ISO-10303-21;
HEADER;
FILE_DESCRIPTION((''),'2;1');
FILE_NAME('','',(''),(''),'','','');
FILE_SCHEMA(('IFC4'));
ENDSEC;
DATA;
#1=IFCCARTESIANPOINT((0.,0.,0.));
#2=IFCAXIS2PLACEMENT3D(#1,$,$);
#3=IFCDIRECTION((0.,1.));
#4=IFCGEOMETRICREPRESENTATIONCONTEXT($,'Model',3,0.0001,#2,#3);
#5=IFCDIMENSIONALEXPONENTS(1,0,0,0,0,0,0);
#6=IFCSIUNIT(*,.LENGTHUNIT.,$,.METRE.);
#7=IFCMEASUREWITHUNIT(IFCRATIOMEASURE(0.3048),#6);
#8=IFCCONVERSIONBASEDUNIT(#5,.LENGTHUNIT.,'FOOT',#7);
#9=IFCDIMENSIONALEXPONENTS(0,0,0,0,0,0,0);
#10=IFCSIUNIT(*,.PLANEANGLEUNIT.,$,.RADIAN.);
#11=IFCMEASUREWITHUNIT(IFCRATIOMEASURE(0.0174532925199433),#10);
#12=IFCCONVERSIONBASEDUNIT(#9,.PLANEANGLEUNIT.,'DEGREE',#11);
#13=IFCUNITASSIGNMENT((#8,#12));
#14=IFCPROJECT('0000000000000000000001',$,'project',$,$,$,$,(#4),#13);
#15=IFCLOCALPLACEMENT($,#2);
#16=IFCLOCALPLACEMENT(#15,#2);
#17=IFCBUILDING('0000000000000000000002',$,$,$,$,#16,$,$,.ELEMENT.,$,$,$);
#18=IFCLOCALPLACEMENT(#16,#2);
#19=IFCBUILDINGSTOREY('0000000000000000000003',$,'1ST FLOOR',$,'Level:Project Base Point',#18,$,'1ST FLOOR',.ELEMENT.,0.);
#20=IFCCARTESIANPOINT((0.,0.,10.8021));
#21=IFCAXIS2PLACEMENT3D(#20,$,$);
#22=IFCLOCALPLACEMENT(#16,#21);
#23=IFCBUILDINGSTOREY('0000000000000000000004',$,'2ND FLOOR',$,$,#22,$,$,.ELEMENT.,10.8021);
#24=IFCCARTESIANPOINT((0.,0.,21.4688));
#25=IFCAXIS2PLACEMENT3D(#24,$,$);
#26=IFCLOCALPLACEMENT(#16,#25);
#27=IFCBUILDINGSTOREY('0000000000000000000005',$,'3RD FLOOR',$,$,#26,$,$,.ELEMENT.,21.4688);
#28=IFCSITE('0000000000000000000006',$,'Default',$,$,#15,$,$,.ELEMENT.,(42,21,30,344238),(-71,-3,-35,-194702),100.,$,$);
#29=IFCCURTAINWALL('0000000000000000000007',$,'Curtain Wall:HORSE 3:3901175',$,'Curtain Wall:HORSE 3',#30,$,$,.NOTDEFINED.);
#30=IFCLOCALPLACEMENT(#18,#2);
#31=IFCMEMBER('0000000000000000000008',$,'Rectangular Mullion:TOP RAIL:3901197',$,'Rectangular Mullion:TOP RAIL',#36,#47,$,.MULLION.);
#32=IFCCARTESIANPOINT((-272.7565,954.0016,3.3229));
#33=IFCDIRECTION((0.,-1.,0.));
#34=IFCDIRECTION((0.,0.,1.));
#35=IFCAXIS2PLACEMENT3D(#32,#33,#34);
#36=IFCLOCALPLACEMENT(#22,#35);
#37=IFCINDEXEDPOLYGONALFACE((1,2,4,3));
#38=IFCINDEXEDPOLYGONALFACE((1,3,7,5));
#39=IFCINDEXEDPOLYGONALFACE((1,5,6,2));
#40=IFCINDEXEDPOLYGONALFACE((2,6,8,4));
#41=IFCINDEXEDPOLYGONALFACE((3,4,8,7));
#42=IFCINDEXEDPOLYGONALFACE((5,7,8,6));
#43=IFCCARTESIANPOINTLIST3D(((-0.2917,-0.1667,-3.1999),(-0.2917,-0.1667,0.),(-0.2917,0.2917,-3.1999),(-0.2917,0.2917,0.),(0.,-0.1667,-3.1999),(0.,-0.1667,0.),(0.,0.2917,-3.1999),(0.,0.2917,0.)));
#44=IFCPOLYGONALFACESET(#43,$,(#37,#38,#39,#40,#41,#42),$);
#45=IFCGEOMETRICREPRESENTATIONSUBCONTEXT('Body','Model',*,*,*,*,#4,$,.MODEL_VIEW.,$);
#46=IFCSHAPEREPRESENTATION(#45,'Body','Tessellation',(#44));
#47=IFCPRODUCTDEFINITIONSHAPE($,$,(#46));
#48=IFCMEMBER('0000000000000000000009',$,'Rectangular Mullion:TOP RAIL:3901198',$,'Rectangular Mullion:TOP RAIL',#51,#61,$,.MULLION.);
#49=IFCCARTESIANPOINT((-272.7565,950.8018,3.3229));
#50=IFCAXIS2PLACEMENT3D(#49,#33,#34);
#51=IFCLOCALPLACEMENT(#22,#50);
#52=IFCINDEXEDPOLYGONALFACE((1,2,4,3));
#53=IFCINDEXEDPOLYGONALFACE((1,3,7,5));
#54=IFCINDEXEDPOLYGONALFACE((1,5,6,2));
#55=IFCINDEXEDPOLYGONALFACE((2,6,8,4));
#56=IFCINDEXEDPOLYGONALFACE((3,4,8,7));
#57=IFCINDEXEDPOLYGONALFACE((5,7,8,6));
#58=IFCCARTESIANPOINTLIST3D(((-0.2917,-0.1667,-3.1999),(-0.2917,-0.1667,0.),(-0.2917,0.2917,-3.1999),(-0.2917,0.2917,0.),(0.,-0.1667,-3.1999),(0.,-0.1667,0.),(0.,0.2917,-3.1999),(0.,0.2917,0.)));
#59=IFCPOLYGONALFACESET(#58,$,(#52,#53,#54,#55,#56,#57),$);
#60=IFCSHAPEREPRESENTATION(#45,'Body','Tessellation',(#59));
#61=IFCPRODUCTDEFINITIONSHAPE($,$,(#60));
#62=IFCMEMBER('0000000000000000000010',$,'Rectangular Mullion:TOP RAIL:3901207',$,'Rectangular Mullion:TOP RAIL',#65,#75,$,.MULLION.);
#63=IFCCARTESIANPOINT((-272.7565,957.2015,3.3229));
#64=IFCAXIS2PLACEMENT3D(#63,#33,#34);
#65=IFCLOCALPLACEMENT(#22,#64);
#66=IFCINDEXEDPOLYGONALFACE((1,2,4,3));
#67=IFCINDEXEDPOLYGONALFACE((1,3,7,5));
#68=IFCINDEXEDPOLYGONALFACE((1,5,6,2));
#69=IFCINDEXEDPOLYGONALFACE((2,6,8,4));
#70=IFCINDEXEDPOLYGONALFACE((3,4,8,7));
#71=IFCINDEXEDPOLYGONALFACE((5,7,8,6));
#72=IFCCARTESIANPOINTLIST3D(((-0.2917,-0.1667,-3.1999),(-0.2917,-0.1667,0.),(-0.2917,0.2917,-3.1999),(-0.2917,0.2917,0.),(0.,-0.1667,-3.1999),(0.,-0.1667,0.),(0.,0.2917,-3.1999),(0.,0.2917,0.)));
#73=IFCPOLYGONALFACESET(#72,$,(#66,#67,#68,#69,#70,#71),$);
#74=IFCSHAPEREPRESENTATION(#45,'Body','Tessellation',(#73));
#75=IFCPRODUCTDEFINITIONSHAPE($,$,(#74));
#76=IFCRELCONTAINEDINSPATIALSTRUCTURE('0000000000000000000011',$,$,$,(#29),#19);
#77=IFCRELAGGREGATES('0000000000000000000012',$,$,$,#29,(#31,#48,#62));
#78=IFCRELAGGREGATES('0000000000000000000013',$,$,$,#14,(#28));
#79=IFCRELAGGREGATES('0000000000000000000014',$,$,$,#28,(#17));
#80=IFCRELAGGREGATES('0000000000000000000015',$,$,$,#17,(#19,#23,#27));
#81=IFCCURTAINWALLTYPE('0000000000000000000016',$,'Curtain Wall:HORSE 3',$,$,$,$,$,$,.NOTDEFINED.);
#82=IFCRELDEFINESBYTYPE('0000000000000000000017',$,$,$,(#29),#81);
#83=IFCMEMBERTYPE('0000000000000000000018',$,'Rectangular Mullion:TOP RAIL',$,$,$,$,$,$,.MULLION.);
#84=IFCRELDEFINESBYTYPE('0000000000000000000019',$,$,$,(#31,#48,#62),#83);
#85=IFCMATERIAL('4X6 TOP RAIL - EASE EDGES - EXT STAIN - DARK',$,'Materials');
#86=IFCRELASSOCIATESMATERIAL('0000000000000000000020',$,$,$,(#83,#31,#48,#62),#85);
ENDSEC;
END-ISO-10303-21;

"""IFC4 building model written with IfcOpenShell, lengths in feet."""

from ifc_helpers import new_model, entity, si_unit, converted_unit, direction, frame, origin, origin_2d_with_axis, place, context, subcontext, project, spatial, rectangle, extrude, source, transform, mapped, material, material_profile, profile_set, profile_usage, type_object, type_shapes, element, aggregate, save


model = new_model("IFC4")

# Units and contexts
model_context = context("Model", 3, precision=0.0001, world=origin(), true_north=direction((0.0, 1.0)))
body_context = subcontext(model_context, "Body", "Model", "MODEL_VIEW")
ifc_project = project(units=[converted_unit("LENGTHUNIT", "FOOT", entity("IfcRatioMeasure", 0.3048), si_unit("LENGTHUNIT", "METRE"), dimensions=[1, 0, 0, 0, 0, 0, 0]), converted_unit("PLANEANGLEUNIT", "DEGREE", entity("IfcRatioMeasure", 0.0174532925199433), si_unit("PLANEANGLEUNIT", "RADIAN"), dimensions=[0, 0, 0, 0, 0, 0, 0])], contexts=[model_context])

# Site, building, storey
site_placement = place(None, origin())
site = spatial("IfcSite", under=ifc_project, at=site_placement, Name="Default", CompositionType="ELEMENT", RefLatitude=(42, 21, 30, 344238), RefLongitude=(-71, -3, -35, -194702), RefElevation=100.0)
building_placement = place(site_placement, origin())
building = spatial("IfcBuilding", under=site, at=building_placement, CompositionType="ELEMENT")
storey_1_placement = place(building_placement, origin())
storey_1 = spatial("IfcBuildingStorey", under=building, at=storey_1_placement, Name="1ST FLOOR", ObjectType="Level:Project Base Point", LongName="1ST FLOOR", CompositionType="ELEMENT", Elevation=0.0)

# Curtain wall, members
curtain_wall_type = type_object("IfcCurtainWallType", Name="Curtain Wall:HORSE 3", PredefinedType="NOTDEFINED")
curtain_wall_placement = place(storey_1_placement, origin())
curtain_wall = element("IfcCurtainWall", 1, at=curtain_wall_placement, inside=storey_1, type_object=curtain_wall_type, Name="Curtain Wall:HORSE 3:3901175", ObjectType="Curtain Wall:HORSE 3", PredefinedType="NOTDEFINED")
storey_2_placement = place(building_placement, frame((0.0, 0.0, 21.4688)))
ifc_material_1 = material(Name="4X6 TOP RAIL - EASE EDGES - EXT STAIN - DARK", Category="Materials")
ifc_material_profile_1 = material_profile(ifc_material_1, rectangle(XDim=0.4583, YDim=0.2917, at=origin_2d_with_axis()), Name="TOP RAIL")
ifc_profile_set_1 = profile_set([ifc_material_profile_1], Name="TOP RAIL")
ifc_profile_usage_1 = profile_usage(ifc_profile_set_1)
member_type_1 = type_object("IfcMemberType", Name="Rectangular Mullion:TOP RAIL", PredefinedType="MULLION", material=ifc_profile_set_1)
shared_shape_1 = source(origin(), body_context, "Body", "SweptSolid", [
    extrude(rectangle(XDim=0.4583, YDim=0.2917, at=origin_2d_with_axis()), frame((-0.1458, 0.0625, -3.1999), z_axis=(0.0, 0.0, 1.0), x_axis=(0.0, -1.0, 0.0)), (0.0, 0.0, 1.0), 3.1999),
])
type_shapes(member_type_1, [shared_shape_1])
storey_3_placement = place(building_placement, frame((0.0, 0.0, 10.8021)))
member_1_placement = place(storey_3_placement, frame((-272.7565, 954.0016, 3.3229), z_axis=(0.0, -1.0, 0.0), x_axis=(0.0, 0.0, 1.0)))
member_1 = element("IfcMember", 2, at=member_1_placement, type_object=member_type_1, material=ifc_profile_usage_1, Name="Rectangular Mullion:TOP RAIL:3901197", ObjectType="Rectangular Mullion:TOP RAIL", PredefinedType="MULLION", context=body_context, shape_type="MappedRepresentation", body=[
    mapped(shared_shape_1, transform((0.0, 0.0, 0.0), scale=1.0)),
])
ifc_profile_usage_2 = profile_usage(ifc_profile_set_1)
member_2_placement = place(storey_3_placement, frame((-272.7565, 950.8018, 3.3229), z_axis=(0.0, -1.0, 0.0), x_axis=(0.0, 0.0, 1.0)))
member_2 = element("IfcMember", 3, at=member_2_placement, type_object=member_type_1, material=ifc_profile_usage_2, Name="Rectangular Mullion:TOP RAIL:3901198", ObjectType="Rectangular Mullion:TOP RAIL", PredefinedType="MULLION", context=body_context, shape_type="MappedRepresentation", body=[
    mapped(shared_shape_1, transform((0.0, 0.0, 0.0), scale=1.0)),
])
ifc_profile_usage_3 = profile_usage(ifc_profile_set_1)
member_3_placement = place(storey_3_placement, frame((-272.7565, 957.2015, 3.3229), z_axis=(0.0, -1.0, 0.0), x_axis=(0.0, 0.0, 1.0)))
member_3 = element("IfcMember", 4, at=member_3_placement, type_object=member_type_1, material=ifc_profile_usage_3, Name="Rectangular Mullion:TOP RAIL:3901207", ObjectType="Rectangular Mullion:TOP RAIL", PredefinedType="MULLION", context=body_context, shape_type="MappedRepresentation", body=[
    mapped(shared_shape_1, transform((0.0, 0.0, 0.0), scale=1.0)),
])
aggregate(curtain_wall, [member_1, member_2, member_3])

# Shared definitions
storey_3 = spatial("IfcBuildingStorey", under=building, at=storey_3_placement, Name="2ND FLOOR", CompositionType="ELEMENT", Elevation=10.8021)

# Shared definitions
storey_2 = spatial("IfcBuildingStorey", under=building, at=storey_2_placement, Name="3RD FLOOR", CompositionType="ELEMENT", Elevation=21.4688)

save(model, "model.ifc")
